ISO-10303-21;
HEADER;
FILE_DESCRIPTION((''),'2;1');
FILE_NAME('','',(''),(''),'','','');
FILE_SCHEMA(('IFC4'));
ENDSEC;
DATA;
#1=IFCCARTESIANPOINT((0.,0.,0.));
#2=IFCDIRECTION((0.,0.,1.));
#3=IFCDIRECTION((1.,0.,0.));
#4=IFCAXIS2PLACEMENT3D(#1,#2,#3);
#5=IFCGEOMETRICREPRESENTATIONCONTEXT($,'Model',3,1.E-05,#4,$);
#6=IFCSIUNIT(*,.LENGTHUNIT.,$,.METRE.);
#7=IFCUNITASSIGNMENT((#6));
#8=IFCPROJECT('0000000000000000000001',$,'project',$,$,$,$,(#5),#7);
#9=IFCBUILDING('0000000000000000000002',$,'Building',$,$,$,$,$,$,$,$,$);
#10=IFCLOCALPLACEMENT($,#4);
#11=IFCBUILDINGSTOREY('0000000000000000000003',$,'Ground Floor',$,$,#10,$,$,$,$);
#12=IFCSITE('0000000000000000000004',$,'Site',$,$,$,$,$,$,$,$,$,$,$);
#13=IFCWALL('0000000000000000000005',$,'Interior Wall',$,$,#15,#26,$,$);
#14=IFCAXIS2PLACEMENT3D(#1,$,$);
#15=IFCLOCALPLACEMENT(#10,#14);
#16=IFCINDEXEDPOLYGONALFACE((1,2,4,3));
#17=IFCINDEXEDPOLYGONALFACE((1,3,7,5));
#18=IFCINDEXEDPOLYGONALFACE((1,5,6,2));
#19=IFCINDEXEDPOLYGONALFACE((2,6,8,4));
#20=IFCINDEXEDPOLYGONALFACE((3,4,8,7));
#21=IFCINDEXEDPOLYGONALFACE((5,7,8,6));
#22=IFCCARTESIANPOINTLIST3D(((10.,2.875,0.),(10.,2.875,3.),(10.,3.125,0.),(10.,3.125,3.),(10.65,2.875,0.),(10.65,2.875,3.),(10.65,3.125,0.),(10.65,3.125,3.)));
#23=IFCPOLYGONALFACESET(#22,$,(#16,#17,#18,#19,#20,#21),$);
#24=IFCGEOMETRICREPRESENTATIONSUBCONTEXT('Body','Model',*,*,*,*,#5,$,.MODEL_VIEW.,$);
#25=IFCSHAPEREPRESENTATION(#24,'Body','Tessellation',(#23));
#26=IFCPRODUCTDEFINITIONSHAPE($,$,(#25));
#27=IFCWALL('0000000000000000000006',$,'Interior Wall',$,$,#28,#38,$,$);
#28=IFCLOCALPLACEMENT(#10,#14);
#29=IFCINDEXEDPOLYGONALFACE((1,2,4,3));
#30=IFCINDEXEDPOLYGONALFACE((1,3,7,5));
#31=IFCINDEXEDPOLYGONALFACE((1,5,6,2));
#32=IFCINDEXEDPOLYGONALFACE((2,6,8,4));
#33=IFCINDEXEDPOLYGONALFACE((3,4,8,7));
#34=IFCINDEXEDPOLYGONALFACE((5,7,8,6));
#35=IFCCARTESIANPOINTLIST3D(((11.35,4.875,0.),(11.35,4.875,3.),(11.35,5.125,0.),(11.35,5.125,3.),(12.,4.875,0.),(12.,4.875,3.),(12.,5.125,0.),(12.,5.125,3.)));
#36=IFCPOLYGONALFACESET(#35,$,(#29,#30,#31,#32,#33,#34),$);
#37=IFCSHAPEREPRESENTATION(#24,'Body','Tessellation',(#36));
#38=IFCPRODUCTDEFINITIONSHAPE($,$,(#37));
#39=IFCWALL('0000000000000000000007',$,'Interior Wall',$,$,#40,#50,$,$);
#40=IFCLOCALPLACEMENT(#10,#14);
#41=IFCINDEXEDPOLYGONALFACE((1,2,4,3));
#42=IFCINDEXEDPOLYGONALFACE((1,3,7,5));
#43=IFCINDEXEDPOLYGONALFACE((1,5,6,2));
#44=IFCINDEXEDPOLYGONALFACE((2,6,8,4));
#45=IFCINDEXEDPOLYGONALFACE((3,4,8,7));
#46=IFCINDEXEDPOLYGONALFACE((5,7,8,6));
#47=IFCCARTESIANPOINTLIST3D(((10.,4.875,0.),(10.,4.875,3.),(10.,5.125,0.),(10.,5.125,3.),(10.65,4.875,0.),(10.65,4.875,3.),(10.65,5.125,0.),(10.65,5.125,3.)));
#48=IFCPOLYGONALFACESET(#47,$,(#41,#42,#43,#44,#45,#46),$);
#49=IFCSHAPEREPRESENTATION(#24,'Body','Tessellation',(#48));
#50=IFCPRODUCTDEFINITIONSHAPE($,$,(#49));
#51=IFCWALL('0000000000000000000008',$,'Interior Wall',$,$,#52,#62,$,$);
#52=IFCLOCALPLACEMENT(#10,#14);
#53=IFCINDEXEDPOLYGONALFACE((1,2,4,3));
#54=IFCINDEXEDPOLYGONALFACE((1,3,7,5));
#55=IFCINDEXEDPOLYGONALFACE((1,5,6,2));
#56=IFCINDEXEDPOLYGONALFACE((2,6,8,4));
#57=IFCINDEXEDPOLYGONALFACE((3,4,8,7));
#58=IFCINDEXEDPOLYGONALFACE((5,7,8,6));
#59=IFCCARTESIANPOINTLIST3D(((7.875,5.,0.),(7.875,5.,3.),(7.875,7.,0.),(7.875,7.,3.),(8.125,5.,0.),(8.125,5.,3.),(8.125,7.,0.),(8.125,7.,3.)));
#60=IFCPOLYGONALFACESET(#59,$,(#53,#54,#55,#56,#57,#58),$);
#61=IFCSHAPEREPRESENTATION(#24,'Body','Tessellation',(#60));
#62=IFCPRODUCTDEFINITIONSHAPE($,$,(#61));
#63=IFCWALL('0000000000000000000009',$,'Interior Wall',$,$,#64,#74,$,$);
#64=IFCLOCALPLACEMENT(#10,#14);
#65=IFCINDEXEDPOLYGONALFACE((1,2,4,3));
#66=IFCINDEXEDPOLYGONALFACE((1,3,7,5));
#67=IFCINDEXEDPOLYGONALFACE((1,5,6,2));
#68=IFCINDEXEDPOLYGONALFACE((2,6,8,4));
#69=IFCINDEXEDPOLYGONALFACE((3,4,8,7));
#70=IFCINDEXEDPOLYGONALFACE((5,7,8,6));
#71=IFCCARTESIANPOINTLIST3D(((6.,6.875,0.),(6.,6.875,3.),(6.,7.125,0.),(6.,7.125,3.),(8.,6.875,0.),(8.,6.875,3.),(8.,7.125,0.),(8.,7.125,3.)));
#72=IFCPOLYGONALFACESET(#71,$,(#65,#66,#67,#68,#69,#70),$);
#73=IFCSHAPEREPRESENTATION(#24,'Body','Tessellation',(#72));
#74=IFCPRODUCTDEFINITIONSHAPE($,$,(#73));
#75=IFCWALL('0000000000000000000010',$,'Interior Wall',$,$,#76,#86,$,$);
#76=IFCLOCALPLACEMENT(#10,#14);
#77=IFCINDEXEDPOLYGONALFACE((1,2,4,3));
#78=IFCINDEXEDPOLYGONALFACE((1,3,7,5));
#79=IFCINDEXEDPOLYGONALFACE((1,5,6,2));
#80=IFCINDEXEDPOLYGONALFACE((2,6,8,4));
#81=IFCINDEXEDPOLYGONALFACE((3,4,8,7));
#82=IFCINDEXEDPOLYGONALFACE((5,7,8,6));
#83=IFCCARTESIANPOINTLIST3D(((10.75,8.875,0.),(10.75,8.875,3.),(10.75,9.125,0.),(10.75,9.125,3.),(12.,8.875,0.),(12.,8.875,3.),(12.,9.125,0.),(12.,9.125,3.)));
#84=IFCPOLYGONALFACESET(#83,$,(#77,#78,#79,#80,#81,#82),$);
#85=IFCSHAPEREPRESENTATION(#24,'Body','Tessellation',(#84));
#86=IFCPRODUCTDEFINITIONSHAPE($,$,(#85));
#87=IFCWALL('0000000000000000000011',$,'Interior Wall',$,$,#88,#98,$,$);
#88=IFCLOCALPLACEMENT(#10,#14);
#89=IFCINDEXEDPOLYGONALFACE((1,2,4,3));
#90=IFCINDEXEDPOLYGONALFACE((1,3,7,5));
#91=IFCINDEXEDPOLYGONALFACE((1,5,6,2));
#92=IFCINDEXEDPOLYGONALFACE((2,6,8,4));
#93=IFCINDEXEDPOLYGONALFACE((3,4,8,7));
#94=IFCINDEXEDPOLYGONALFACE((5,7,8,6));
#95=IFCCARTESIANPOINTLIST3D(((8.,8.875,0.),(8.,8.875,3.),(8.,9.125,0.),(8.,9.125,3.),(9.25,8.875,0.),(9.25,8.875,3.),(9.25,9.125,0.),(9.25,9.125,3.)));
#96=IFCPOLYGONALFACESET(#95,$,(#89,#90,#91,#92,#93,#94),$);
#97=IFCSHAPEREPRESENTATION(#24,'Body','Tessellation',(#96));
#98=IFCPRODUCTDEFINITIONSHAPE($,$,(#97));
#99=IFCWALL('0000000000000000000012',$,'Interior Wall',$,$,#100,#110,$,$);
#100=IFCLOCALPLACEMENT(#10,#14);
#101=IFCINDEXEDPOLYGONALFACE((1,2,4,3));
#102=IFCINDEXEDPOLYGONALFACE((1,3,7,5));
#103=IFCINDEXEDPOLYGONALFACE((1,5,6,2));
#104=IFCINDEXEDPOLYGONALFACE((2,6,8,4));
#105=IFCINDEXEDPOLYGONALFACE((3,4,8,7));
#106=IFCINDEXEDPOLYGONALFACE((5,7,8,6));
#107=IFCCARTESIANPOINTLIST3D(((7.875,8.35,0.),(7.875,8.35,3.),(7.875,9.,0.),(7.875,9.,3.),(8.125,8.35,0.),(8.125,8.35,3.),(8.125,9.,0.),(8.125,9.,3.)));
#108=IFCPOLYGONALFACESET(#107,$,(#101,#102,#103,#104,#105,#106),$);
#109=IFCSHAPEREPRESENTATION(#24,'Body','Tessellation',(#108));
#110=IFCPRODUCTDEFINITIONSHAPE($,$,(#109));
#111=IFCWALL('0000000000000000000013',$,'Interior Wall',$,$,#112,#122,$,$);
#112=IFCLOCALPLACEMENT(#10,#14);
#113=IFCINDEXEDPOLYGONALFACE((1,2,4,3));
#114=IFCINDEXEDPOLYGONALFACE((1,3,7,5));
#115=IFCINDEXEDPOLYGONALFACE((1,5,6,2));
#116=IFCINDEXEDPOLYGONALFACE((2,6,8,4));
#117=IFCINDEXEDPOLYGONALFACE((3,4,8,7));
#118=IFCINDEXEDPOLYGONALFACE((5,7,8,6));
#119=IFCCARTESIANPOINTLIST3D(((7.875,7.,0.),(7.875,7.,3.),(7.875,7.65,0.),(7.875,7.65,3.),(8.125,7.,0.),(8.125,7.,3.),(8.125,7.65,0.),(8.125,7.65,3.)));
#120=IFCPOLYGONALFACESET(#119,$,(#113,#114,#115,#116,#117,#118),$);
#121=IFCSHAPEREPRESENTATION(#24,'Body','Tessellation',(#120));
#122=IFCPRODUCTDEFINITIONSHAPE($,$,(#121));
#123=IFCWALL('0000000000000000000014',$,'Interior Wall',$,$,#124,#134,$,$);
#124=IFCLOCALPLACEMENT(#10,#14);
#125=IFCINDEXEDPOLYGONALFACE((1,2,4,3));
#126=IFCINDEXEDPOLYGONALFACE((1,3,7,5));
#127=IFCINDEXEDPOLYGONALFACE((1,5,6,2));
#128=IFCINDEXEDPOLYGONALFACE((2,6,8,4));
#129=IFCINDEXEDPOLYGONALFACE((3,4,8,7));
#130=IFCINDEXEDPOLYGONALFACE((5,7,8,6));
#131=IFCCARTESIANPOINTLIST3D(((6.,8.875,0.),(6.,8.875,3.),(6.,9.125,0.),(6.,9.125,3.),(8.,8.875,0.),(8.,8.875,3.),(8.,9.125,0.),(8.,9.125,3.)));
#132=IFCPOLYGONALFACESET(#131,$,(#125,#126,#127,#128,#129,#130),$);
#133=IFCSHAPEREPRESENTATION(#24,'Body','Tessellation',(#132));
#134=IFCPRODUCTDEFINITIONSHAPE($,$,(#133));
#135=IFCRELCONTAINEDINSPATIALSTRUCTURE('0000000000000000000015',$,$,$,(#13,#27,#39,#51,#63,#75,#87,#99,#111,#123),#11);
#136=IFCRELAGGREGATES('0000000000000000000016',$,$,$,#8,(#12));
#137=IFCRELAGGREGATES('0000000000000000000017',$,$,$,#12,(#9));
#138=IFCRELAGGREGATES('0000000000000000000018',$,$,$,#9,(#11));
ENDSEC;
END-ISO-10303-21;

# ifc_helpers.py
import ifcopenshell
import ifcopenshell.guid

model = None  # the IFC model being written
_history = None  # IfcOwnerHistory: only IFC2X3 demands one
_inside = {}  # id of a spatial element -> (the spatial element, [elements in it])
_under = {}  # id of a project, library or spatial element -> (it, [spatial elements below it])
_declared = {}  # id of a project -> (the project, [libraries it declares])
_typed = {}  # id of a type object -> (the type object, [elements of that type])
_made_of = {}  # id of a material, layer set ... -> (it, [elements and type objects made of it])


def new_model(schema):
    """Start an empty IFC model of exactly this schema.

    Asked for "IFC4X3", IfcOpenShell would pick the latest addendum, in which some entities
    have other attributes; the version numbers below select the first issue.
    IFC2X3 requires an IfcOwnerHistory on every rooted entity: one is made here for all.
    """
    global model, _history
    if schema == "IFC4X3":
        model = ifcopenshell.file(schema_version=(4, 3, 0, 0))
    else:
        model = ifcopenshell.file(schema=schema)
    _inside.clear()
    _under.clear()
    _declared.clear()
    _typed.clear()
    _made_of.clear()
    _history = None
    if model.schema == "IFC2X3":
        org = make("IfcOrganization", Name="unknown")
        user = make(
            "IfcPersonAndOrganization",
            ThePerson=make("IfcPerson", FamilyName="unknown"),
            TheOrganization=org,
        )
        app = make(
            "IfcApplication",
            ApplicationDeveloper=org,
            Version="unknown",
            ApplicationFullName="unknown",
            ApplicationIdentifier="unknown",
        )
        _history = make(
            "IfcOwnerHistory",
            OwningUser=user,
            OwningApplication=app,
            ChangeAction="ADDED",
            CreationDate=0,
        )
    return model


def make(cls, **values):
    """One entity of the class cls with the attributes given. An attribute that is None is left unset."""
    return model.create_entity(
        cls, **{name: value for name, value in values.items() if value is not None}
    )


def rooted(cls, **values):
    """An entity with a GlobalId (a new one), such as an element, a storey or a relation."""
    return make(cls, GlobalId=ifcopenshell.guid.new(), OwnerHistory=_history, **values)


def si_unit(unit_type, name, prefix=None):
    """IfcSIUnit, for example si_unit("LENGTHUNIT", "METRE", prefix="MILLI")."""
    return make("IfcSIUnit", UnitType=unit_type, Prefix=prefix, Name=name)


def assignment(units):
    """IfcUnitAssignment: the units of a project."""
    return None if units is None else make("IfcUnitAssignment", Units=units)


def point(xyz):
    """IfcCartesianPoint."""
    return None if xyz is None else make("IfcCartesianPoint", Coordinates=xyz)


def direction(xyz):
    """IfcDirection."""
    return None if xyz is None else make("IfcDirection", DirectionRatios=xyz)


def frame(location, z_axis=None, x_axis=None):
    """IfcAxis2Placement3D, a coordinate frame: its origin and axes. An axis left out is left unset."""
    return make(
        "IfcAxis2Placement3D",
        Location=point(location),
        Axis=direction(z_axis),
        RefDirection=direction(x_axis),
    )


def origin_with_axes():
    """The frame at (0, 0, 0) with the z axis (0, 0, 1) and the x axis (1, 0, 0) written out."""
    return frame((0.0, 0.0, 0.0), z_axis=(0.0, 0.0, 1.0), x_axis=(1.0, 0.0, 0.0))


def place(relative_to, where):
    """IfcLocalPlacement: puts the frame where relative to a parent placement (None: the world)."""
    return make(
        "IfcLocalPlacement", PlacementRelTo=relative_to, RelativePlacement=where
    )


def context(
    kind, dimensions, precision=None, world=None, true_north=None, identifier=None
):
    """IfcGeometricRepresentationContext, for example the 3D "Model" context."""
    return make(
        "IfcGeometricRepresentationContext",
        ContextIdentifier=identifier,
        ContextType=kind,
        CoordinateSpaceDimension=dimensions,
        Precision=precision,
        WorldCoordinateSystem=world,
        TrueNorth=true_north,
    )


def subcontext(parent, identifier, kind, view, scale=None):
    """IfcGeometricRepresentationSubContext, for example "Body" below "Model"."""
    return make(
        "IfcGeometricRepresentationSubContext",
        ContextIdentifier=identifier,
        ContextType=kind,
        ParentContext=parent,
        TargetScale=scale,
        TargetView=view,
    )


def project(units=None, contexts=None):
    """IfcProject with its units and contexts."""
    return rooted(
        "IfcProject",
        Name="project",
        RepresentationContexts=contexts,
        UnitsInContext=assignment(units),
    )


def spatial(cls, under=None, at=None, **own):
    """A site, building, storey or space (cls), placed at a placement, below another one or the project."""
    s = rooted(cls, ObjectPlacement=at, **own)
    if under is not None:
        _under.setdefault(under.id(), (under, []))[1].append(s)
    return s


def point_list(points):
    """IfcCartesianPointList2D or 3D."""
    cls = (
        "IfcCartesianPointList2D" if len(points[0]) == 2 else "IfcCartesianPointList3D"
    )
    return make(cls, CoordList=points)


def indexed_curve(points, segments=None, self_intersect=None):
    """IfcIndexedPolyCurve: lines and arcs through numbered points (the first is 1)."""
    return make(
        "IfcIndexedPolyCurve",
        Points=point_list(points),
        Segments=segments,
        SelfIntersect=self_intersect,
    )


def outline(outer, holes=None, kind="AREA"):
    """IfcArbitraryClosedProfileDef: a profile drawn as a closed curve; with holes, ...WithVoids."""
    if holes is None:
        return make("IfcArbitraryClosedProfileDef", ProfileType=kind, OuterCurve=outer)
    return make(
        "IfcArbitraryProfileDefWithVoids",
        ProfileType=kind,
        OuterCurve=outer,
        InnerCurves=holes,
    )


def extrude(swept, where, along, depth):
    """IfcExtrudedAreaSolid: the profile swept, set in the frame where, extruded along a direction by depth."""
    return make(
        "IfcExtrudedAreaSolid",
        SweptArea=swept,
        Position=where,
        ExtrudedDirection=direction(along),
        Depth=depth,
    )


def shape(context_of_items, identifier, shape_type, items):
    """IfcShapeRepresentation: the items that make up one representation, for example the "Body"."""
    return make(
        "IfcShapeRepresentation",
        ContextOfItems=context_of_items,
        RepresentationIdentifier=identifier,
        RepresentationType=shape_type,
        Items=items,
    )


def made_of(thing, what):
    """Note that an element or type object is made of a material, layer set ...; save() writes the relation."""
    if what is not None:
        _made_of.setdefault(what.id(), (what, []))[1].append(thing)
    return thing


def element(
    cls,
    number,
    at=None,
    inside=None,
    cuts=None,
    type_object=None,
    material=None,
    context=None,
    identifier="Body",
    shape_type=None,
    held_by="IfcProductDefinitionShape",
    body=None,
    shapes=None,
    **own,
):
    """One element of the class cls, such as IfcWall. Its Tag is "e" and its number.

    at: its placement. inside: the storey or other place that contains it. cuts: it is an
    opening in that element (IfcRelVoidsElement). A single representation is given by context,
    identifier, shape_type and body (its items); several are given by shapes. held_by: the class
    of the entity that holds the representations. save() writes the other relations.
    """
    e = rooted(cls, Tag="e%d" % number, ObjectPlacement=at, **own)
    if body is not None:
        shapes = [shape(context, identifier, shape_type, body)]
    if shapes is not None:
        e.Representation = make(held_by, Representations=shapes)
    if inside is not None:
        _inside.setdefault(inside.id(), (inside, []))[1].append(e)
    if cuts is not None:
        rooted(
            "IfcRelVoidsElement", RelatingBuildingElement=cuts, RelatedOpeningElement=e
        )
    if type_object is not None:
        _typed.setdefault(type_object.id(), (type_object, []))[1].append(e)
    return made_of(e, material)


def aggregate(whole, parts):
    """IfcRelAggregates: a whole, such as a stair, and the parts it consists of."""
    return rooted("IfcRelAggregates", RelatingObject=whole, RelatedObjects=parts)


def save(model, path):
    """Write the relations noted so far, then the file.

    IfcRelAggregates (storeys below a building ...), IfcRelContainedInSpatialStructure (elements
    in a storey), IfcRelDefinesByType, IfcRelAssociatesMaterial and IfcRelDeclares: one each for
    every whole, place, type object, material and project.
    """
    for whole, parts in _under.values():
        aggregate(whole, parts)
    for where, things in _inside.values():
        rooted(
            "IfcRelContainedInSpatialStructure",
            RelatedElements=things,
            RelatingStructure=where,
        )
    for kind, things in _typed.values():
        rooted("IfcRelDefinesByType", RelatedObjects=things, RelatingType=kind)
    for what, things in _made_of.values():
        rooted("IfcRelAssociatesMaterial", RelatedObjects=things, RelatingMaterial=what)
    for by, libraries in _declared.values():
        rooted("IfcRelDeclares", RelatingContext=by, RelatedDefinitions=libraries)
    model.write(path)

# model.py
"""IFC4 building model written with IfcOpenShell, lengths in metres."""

from ifc_helpers import new_model, si_unit, frame, origin_with_axes, place, context, subcontext, project, spatial, indexed_curve, outline, extrude, element, save


model = new_model("IFC4")

# Units and contexts
model_context = context("Model", 3, precision=1e-05, world=origin_with_axes())
body_context = subcontext(model_context, "Body", "Model", "MODEL_VIEW")
ifc_project = project(units=[si_unit("LENGTHUNIT", "METRE")], contexts=[model_context])

# Site, building, storey
site = spatial("IfcSite", under=ifc_project, Name="Site")
building = spatial("IfcBuilding", under=site, Name="Building")
storey_placement = place(None, origin_with_axes())
storey = spatial("IfcBuildingStorey", under=building, at=storey_placement, Name="Ground Floor")

# Walls
for number, where, z_axis, x_axis, name in (
    (1, (10.65, 3.0, 0.0), (0.0, 0.0, 1.0), (-1.0, 0.0, 0.0), "Interior Wall"),
    (2, (12.0, 5.0, 0.0), (0.0, 0.0, 1.0), (-1.0, 0.0, 0.0), "Interior Wall"),
    (3, (10.65, 5.0, 0.0), (0.0, 0.0, 1.0), (-1.0, 0.0, 0.0), "Interior Wall"),
):
    element("IfcWall", number, at=place(storey_placement, frame(where, z_axis=z_axis, x_axis=x_axis)), inside=storey, Name=name, context=body_context, shape_type="SweptSolid", body=[
        extrude(outline(indexed_curve([(0.0, 0.0), (0.0, 0.25), (0.65, 0.25), (0.65, 0.0), (0.0, 0.0)], self_intersect=False)), frame((0.0, -0.125, 0.0), z_axis=(0.0, 0.0, 1.0), x_axis=(1.0, 0.0, 0.0)), (0.0, 0.0, 1.0), 3.0),
    ])
for number, where, z_axis, x_axis, name in (
    (4, (8.0, 5.0, 0.0), (0.0, 0.0, 1.0), (0.0, 1.0, 0.0), "Interior Wall"),
    (5, (8.0, 7.0, 0.0), (0.0, 0.0, 1.0), (-1.0, 0.0, 0.0), "Interior Wall"),
):
    element("IfcWall", number, at=place(storey_placement, frame(where, z_axis=z_axis, x_axis=x_axis)), inside=storey, Name=name, context=body_context, shape_type="SweptSolid", body=[
        extrude(outline(indexed_curve([(0.0, 0.0), (0.0, 0.25), (2.0, 0.25), (2.0, 0.0), (0.0, 0.0)], self_intersect=False)), frame((0.0, -0.125, 0.0), z_axis=(0.0, 0.0, 1.0), x_axis=(1.0, 0.0, 0.0)), (0.0, 0.0, 1.0), 3.0),
    ])
for number, where, z_axis, x_axis, name in (
    (6, (12.0, 9.0, 0.0), (0.0, 0.0, 1.0), (-1.0, 0.0, 0.0), "Interior Wall"),
    (7, (9.25, 9.0, 0.0), (0.0, 0.0, 1.0), (-1.0, 0.0, 0.0), "Interior Wall"),
):
    element("IfcWall", number, at=place(storey_placement, frame(where, z_axis=z_axis, x_axis=x_axis)), inside=storey, Name=name, context=body_context, shape_type="SweptSolid", body=[
        extrude(outline(indexed_curve([(0.0, 0.0), (0.0, 0.25), (1.25, 0.25), (1.25, 0.0), (0.0, 0.0)], self_intersect=False)), frame((0.0, -0.125, 0.0), z_axis=(0.0, 0.0, 1.0), x_axis=(1.0, 0.0, 0.0)), (0.0, 0.0, 1.0), 3.0),
    ])
for number, where, z_axis, x_axis, name in (
    (8, (8.0, 9.0, 0.0), (0.0, 0.0, 1.0), (0.0, -1.0, 0.0), "Interior Wall"),
    (9, (8.0, 7.65, 0.0), (0.0, 0.0, 1.0), (0.0, -1.0, 0.0), "Interior Wall"),
):
    element("IfcWall", number, at=place(storey_placement, frame(where, z_axis=z_axis, x_axis=x_axis)), inside=storey, Name=name, context=body_context, shape_type="SweptSolid", body=[
        extrude(outline(indexed_curve([(0.0, 0.0), (0.0, 0.25), (0.65, 0.25), (0.65, 0.0), (0.0, 0.0)], self_intersect=False)), frame((0.0, -0.125, 0.0), z_axis=(0.0, 0.0, 1.0), x_axis=(1.0, 0.0, 0.0)), (0.0, 0.0, 1.0), 3.0),
    ])
wall_1_placement = place(storey_placement, frame((8.0, 9.0, 0.0), z_axis=(0.0, 0.0, 1.0), x_axis=(-1.0, 0.0, 0.0)))
element("IfcWall", 10, at=wall_1_placement, inside=storey, Name="Interior Wall", context=body_context, shape_type="SweptSolid", body=[
    extrude(outline(indexed_curve([(0.0, 0.0), (0.0, 0.25), (2.0, 0.25), (2.0, 0.0), (0.0, 0.0)], self_intersect=False)), frame((0.0, -0.125, 0.0), z_axis=(0.0, 0.0, 1.0), x_axis=(1.0, 0.0, 0.0)), (0.0, 0.0, 1.0), 3.0),
])

save(model, "model.ifc")
